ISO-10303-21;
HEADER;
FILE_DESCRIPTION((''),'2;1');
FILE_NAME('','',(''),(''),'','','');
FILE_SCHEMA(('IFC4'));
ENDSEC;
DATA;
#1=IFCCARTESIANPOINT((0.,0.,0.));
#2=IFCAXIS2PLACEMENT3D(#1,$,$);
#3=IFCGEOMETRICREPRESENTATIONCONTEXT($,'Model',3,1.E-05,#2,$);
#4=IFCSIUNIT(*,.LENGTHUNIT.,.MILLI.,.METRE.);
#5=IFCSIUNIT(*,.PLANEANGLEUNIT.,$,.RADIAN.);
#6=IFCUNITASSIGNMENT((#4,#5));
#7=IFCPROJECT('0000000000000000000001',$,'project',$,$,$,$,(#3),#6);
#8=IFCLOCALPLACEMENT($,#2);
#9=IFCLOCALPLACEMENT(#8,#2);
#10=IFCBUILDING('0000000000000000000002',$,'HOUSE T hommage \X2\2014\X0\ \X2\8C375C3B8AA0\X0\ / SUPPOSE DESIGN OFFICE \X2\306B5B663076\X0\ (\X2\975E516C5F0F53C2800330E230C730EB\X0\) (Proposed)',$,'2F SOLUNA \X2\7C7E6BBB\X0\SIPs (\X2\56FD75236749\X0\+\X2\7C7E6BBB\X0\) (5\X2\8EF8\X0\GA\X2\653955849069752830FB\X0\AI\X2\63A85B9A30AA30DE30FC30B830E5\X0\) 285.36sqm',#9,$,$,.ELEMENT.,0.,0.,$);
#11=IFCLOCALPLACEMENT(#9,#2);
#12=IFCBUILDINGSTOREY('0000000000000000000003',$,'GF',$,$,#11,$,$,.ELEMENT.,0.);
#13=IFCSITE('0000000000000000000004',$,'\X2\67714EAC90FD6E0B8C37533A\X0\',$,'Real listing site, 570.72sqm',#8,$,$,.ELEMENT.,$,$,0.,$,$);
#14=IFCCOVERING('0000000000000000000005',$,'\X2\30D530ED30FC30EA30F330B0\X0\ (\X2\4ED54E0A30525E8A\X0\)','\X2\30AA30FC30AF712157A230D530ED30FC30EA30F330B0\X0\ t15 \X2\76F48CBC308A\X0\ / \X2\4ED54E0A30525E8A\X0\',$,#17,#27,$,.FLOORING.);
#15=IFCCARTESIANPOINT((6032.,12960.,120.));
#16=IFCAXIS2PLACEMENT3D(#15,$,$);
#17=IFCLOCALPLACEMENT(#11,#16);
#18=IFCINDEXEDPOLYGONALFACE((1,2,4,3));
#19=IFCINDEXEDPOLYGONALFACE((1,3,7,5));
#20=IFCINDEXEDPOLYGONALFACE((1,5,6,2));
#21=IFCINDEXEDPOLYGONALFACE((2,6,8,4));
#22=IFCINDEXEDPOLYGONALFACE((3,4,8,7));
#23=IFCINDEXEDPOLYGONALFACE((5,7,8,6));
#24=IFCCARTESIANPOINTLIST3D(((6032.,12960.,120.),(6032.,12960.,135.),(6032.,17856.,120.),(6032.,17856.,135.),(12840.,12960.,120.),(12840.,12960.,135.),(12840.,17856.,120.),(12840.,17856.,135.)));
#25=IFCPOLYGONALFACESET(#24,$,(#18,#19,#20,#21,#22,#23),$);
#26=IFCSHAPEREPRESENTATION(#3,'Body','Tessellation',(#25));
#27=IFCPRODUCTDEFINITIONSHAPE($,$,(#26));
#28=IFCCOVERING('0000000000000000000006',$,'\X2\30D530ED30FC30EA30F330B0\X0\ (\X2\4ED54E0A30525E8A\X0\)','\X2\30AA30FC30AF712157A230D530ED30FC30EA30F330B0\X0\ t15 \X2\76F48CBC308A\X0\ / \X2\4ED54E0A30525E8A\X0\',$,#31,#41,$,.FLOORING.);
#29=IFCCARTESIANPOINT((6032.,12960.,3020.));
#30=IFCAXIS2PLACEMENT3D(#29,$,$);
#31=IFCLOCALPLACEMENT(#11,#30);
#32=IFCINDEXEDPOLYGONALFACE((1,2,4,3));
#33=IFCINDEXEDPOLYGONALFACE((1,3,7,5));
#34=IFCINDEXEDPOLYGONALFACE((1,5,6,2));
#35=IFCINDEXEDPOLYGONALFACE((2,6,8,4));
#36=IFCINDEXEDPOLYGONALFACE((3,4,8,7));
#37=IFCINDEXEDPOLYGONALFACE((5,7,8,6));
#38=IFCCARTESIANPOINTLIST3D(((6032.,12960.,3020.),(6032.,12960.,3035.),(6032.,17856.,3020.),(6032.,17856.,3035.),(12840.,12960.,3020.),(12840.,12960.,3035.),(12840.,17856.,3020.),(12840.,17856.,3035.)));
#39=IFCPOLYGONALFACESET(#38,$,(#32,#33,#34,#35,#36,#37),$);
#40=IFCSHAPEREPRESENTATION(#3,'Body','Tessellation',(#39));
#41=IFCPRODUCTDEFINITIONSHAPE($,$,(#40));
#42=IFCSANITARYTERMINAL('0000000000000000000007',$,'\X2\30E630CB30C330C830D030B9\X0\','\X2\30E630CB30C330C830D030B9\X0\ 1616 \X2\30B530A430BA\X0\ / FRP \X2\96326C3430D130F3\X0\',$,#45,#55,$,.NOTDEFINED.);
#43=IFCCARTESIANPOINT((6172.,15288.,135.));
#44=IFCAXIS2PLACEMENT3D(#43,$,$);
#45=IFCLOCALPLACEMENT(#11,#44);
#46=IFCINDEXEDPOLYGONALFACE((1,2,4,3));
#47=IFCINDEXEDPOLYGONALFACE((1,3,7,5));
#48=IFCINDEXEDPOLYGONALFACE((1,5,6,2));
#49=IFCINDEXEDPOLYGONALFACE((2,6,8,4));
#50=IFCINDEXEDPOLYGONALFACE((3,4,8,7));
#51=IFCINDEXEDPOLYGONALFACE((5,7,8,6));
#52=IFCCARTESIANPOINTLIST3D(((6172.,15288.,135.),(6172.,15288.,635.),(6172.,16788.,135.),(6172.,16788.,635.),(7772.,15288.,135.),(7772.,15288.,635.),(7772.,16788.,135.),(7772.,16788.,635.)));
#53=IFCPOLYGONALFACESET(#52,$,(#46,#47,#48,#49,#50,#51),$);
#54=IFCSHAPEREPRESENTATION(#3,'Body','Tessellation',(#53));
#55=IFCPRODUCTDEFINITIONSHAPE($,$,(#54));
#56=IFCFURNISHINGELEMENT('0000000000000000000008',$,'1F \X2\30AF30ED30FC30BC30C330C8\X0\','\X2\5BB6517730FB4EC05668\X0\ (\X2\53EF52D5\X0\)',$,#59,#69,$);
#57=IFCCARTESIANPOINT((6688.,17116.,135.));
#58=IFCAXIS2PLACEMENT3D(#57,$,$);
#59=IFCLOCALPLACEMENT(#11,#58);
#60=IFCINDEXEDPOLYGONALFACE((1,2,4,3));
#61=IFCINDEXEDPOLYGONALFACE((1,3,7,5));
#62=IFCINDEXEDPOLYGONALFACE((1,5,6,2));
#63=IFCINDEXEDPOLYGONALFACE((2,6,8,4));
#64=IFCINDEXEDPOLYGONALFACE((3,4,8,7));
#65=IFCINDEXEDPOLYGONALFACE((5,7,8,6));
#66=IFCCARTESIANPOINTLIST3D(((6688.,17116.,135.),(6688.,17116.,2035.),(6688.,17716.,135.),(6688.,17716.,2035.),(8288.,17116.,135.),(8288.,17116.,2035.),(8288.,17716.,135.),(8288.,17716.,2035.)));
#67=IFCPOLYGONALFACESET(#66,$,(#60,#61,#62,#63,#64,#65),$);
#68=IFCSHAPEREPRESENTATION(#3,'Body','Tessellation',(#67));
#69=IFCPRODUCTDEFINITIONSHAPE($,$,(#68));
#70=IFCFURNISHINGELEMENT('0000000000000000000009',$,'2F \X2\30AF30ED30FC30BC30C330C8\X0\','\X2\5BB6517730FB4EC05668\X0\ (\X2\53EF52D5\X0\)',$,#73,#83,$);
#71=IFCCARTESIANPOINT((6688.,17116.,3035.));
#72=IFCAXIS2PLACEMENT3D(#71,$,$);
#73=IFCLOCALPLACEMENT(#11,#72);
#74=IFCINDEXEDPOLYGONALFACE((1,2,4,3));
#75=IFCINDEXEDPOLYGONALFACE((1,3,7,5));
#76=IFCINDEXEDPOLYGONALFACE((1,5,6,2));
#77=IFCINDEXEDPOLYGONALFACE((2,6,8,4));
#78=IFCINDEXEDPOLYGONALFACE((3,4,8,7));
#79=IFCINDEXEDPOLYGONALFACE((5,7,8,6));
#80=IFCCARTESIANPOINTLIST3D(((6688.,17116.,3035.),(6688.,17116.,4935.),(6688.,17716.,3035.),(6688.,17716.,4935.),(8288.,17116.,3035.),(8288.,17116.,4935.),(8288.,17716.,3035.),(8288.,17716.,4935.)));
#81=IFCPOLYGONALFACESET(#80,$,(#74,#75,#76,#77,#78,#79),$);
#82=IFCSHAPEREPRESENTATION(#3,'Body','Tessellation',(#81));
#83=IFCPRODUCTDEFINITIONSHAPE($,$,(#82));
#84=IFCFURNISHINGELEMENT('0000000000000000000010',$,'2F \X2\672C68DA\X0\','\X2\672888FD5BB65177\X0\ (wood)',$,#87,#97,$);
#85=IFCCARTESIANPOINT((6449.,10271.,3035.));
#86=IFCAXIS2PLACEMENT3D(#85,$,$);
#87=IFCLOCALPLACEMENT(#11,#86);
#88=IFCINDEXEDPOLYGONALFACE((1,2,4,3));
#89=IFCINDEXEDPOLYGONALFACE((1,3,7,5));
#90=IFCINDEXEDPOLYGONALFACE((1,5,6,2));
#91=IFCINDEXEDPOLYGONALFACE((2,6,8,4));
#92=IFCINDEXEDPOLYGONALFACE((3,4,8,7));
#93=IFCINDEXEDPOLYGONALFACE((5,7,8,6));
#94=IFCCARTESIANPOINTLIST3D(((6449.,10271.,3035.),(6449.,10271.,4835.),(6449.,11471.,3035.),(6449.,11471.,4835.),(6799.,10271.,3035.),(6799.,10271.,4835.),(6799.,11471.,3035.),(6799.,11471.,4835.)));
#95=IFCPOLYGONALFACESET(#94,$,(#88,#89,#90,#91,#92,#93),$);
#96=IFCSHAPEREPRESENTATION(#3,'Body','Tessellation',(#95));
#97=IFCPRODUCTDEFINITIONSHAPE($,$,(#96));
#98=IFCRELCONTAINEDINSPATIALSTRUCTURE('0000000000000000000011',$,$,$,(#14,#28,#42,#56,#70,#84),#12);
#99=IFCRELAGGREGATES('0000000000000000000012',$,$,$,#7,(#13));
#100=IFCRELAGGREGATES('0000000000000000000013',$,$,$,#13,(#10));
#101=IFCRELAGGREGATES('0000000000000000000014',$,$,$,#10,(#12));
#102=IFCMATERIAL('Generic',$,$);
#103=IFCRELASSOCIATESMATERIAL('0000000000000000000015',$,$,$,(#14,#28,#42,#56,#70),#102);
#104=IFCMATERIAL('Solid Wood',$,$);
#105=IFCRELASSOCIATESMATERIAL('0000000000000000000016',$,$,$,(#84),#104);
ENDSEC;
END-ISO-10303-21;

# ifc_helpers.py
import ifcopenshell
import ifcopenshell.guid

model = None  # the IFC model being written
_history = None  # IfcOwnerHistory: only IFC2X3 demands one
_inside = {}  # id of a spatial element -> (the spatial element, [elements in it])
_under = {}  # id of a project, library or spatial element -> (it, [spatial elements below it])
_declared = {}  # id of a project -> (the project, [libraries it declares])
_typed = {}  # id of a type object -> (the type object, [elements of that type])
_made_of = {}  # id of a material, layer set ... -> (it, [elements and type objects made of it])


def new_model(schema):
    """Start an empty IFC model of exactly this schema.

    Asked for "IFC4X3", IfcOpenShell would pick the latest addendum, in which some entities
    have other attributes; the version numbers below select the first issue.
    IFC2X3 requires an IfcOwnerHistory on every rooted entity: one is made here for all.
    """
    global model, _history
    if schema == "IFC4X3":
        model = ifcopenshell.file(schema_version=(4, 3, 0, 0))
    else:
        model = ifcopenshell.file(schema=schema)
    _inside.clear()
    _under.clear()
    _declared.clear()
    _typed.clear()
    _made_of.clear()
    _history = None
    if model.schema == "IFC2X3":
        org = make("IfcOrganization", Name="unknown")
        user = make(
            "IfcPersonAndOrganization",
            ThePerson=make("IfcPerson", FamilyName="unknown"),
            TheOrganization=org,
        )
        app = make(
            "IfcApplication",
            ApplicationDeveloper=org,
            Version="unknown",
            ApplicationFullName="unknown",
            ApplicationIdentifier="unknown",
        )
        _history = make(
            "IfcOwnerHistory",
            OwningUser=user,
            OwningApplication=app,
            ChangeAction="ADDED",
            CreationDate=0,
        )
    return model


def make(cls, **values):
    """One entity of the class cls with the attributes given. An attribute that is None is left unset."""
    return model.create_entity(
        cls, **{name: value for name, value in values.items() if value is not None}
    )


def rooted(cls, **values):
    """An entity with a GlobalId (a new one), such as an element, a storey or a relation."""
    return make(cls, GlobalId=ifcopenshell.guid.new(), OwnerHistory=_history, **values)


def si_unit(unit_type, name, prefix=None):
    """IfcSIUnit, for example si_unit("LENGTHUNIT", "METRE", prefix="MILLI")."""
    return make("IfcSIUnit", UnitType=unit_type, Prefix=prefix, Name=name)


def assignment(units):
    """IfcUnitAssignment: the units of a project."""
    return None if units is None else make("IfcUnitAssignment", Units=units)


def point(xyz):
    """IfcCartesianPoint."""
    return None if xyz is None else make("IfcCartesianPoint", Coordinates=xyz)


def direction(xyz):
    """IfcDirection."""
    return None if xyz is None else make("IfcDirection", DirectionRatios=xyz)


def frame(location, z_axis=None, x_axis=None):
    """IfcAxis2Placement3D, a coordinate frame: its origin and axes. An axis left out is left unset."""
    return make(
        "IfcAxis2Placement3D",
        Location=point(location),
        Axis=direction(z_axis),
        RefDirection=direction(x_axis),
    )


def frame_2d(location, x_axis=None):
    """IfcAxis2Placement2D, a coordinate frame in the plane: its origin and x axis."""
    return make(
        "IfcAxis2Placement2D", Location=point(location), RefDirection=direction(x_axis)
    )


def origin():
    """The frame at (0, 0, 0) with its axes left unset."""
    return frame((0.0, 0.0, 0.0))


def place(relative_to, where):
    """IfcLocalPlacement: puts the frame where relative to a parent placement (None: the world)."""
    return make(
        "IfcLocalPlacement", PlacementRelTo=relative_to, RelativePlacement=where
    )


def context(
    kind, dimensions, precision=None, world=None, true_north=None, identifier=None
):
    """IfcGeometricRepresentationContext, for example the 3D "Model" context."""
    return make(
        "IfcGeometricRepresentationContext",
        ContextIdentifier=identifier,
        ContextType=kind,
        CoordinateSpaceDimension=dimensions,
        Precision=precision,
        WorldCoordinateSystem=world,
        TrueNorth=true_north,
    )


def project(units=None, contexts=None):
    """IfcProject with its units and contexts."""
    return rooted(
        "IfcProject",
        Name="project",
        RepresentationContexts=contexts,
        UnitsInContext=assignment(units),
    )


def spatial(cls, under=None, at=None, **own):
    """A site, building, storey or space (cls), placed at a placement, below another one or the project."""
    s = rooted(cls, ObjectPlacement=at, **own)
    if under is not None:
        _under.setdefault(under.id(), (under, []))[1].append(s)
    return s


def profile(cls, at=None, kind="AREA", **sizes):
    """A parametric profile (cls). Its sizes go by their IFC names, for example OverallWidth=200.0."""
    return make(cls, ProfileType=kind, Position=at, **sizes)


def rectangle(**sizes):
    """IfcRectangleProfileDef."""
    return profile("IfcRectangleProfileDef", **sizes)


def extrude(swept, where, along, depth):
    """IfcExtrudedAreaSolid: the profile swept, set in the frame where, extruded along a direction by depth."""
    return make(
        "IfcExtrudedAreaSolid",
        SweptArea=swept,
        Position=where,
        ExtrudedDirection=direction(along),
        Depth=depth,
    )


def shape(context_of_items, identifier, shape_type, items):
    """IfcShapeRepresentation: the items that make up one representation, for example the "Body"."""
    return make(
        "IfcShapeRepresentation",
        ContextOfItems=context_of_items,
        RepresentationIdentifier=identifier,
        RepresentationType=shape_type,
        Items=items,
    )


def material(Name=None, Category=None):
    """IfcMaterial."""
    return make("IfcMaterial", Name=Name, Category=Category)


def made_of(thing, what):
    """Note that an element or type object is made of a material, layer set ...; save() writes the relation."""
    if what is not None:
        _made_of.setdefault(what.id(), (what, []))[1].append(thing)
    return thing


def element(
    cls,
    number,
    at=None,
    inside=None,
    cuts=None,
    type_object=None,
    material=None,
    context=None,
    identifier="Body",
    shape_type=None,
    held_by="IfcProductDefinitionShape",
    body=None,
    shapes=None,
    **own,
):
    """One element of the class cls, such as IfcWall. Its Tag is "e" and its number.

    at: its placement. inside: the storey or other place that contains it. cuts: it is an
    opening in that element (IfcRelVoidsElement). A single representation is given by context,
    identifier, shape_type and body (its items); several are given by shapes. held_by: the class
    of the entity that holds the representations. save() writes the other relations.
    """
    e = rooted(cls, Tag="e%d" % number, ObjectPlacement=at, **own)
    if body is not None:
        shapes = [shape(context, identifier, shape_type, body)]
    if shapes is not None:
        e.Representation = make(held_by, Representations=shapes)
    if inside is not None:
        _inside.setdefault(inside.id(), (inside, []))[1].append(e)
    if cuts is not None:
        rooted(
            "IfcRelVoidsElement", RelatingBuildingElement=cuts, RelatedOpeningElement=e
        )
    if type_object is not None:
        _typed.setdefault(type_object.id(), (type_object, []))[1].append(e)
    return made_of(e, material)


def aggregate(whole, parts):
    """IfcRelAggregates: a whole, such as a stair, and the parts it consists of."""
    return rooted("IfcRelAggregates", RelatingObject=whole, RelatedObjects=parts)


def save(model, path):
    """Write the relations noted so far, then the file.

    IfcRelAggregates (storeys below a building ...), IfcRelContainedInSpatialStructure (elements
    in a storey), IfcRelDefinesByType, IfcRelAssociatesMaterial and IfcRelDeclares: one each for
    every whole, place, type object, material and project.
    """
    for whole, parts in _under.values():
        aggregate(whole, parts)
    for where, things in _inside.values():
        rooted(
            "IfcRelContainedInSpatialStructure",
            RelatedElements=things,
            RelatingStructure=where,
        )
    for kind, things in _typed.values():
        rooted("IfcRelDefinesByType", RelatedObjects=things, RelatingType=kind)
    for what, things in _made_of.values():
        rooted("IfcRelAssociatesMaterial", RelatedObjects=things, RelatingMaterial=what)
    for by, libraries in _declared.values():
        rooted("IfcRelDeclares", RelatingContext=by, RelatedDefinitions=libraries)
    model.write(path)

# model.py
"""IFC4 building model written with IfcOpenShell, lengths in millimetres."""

from ifc_helpers import new_model, si_unit, frame, frame_2d, origin, place, context, project, spatial, rectangle, extrude, material, element, save


model = new_model("IFC4")

# Units and contexts
model_context = context("Model", 3, precision=1e-05, world=origin())
ifc_project = project(units=[si_unit("LENGTHUNIT", "METRE", prefix="MILLI"), si_unit("PLANEANGLEUNIT", "RADIAN")], contexts=[model_context])

# Site, building, storey
site_placement = place(None, origin())
site = spatial("IfcSite", under=ifc_project, at=site_placement, Name="東京都渋谷区", ObjectType="Real listing site, 570.72sqm", CompositionType="ELEMENT", RefElevation=0.0)
building_placement = place(site_placement, origin())
building = spatial("IfcBuilding", under=site, at=building_placement, Name="HOUSE T hommage — 谷尻誠 / SUPPOSE DESIGN OFFICE に学ぶ (非公式参考モデル) (Proposed)", ObjectType="2F SOLUNA 籾殻SIPs (国産杉+籾殻) (5軸GA改善適用・AI推定オマージュ) 285.36sqm", CompositionType="ELEMENT", ElevationOfRefHeight=0.0, ElevationOfTerrain=0.0)
storey_placement = place(building_placement, origin())
storey = spatial("IfcBuildingStorey", under=building, at=storey_placement, Name="GF", CompositionType="ELEMENT", Elevation=0.0)

# Shared definitions
ifc_material_1 = material(Name="Solid Wood")

# Coverings
ifc_material_2 = material(Name="Generic")
covering_1_placement = place(storey_placement, frame((6032.0, 12960.0, 120.0)))
element("IfcCovering", 1, at=covering_1_placement, inside=storey, material=ifc_material_2, Name="フローリング (仕上げ床)", Description="オーク無垢フローリング t15 直貼り / 仕上げ床", PredefinedType="FLOORING", context=model_context, shape_type="SweptSolid", body=[
    extrude(rectangle(XDim=6808.0, YDim=4896.0, at=frame_2d((3404.0, 2448.0))), frame((6032.0, 12960.0, 120.0)), (0.0, 0.0, 1.0), 15.0),
])
covering_2_placement = place(storey_placement, frame((6032.0, 12960.0, 3020.0)))
element("IfcCovering", 2, at=covering_2_placement, inside=storey, material=ifc_material_2, Name="フローリング (仕上げ床)", Description="オーク無垢フローリング t15 直貼り / 仕上げ床", PredefinedType="FLOORING", context=model_context, shape_type="SweptSolid", body=[
    extrude(rectangle(XDim=6808.0, YDim=4896.0, at=frame_2d((3404.0, 2448.0))), frame((6032.0, 12960.0, 3020.0)), (0.0, 0.0, 1.0), 15.0),
])

# Sanitary terminal
sanitary_terminal_placement = place(storey_placement, frame((6172.0, 15288.0, 135.0)))
element("IfcSanitaryTerminal", 3, at=sanitary_terminal_placement, inside=storey, material=ifc_material_2, Name="ユニットバス", Description="ユニットバス 1616 サイズ / FRP 防水パン", PredefinedType="NOTDEFINED", context=model_context, shape_type="SweptSolid", body=[
    extrude(rectangle(XDim=1600.0, YDim=1500.0, at=frame_2d((800.0, 750.0))), frame((6172.0, 15288.0, 135.0)), (0.0, 0.0, 1.0), 500.0),
])

# Furnishing elements
furnishing_1_placement = place(storey_placement, frame((6688.0, 17116.0, 135.0)))
element("IfcFurnishingElement", 4, at=furnishing_1_placement, inside=storey, material=ifc_material_2, Name="1F クローゼット", Description="家具・什器 (可動)", context=model_context, shape_type="SweptSolid", body=[
    extrude(rectangle(XDim=1600.0, YDim=600.0, at=frame_2d((800.0, 300.0))), frame((6688.0, 17116.0, 135.0)), (0.0, 0.0, 1.0), 1900.0),
])
furnishing_2_placement = place(storey_placement, frame((6688.0, 17116.0, 3035.0)))
element("IfcFurnishingElement", 5, at=furnishing_2_placement, inside=storey, material=ifc_material_2, Name="2F クローゼット", Description="家具・什器 (可動)", context=model_context, shape_type="SweptSolid", body=[
    extrude(rectangle(XDim=1600.0, YDim=600.0, at=frame_2d((800.0, 300.0))), frame((6688.0, 17116.0, 3035.0)), (0.0, 0.0, 1.0), 1900.0),
])
furnishing_3_placement = place(storey_placement, frame((6449.0, 10271.0, 3035.0)))
element("IfcFurnishingElement", 6, at=furnishing_3_placement, inside=storey, material=ifc_material_1, Name="2F 本棚", Description="木製家具 (wood)", context=model_context, shape_type="SweptSolid", body=[
    extrude(rectangle(XDim=350.0, YDim=1200.0, at=frame_2d((175.0, 600.0))), frame((6449.0, 10271.0, 3035.0)), (0.0, 0.0, 1.0), 1800.0),
])

save(model, "model.ifc")
